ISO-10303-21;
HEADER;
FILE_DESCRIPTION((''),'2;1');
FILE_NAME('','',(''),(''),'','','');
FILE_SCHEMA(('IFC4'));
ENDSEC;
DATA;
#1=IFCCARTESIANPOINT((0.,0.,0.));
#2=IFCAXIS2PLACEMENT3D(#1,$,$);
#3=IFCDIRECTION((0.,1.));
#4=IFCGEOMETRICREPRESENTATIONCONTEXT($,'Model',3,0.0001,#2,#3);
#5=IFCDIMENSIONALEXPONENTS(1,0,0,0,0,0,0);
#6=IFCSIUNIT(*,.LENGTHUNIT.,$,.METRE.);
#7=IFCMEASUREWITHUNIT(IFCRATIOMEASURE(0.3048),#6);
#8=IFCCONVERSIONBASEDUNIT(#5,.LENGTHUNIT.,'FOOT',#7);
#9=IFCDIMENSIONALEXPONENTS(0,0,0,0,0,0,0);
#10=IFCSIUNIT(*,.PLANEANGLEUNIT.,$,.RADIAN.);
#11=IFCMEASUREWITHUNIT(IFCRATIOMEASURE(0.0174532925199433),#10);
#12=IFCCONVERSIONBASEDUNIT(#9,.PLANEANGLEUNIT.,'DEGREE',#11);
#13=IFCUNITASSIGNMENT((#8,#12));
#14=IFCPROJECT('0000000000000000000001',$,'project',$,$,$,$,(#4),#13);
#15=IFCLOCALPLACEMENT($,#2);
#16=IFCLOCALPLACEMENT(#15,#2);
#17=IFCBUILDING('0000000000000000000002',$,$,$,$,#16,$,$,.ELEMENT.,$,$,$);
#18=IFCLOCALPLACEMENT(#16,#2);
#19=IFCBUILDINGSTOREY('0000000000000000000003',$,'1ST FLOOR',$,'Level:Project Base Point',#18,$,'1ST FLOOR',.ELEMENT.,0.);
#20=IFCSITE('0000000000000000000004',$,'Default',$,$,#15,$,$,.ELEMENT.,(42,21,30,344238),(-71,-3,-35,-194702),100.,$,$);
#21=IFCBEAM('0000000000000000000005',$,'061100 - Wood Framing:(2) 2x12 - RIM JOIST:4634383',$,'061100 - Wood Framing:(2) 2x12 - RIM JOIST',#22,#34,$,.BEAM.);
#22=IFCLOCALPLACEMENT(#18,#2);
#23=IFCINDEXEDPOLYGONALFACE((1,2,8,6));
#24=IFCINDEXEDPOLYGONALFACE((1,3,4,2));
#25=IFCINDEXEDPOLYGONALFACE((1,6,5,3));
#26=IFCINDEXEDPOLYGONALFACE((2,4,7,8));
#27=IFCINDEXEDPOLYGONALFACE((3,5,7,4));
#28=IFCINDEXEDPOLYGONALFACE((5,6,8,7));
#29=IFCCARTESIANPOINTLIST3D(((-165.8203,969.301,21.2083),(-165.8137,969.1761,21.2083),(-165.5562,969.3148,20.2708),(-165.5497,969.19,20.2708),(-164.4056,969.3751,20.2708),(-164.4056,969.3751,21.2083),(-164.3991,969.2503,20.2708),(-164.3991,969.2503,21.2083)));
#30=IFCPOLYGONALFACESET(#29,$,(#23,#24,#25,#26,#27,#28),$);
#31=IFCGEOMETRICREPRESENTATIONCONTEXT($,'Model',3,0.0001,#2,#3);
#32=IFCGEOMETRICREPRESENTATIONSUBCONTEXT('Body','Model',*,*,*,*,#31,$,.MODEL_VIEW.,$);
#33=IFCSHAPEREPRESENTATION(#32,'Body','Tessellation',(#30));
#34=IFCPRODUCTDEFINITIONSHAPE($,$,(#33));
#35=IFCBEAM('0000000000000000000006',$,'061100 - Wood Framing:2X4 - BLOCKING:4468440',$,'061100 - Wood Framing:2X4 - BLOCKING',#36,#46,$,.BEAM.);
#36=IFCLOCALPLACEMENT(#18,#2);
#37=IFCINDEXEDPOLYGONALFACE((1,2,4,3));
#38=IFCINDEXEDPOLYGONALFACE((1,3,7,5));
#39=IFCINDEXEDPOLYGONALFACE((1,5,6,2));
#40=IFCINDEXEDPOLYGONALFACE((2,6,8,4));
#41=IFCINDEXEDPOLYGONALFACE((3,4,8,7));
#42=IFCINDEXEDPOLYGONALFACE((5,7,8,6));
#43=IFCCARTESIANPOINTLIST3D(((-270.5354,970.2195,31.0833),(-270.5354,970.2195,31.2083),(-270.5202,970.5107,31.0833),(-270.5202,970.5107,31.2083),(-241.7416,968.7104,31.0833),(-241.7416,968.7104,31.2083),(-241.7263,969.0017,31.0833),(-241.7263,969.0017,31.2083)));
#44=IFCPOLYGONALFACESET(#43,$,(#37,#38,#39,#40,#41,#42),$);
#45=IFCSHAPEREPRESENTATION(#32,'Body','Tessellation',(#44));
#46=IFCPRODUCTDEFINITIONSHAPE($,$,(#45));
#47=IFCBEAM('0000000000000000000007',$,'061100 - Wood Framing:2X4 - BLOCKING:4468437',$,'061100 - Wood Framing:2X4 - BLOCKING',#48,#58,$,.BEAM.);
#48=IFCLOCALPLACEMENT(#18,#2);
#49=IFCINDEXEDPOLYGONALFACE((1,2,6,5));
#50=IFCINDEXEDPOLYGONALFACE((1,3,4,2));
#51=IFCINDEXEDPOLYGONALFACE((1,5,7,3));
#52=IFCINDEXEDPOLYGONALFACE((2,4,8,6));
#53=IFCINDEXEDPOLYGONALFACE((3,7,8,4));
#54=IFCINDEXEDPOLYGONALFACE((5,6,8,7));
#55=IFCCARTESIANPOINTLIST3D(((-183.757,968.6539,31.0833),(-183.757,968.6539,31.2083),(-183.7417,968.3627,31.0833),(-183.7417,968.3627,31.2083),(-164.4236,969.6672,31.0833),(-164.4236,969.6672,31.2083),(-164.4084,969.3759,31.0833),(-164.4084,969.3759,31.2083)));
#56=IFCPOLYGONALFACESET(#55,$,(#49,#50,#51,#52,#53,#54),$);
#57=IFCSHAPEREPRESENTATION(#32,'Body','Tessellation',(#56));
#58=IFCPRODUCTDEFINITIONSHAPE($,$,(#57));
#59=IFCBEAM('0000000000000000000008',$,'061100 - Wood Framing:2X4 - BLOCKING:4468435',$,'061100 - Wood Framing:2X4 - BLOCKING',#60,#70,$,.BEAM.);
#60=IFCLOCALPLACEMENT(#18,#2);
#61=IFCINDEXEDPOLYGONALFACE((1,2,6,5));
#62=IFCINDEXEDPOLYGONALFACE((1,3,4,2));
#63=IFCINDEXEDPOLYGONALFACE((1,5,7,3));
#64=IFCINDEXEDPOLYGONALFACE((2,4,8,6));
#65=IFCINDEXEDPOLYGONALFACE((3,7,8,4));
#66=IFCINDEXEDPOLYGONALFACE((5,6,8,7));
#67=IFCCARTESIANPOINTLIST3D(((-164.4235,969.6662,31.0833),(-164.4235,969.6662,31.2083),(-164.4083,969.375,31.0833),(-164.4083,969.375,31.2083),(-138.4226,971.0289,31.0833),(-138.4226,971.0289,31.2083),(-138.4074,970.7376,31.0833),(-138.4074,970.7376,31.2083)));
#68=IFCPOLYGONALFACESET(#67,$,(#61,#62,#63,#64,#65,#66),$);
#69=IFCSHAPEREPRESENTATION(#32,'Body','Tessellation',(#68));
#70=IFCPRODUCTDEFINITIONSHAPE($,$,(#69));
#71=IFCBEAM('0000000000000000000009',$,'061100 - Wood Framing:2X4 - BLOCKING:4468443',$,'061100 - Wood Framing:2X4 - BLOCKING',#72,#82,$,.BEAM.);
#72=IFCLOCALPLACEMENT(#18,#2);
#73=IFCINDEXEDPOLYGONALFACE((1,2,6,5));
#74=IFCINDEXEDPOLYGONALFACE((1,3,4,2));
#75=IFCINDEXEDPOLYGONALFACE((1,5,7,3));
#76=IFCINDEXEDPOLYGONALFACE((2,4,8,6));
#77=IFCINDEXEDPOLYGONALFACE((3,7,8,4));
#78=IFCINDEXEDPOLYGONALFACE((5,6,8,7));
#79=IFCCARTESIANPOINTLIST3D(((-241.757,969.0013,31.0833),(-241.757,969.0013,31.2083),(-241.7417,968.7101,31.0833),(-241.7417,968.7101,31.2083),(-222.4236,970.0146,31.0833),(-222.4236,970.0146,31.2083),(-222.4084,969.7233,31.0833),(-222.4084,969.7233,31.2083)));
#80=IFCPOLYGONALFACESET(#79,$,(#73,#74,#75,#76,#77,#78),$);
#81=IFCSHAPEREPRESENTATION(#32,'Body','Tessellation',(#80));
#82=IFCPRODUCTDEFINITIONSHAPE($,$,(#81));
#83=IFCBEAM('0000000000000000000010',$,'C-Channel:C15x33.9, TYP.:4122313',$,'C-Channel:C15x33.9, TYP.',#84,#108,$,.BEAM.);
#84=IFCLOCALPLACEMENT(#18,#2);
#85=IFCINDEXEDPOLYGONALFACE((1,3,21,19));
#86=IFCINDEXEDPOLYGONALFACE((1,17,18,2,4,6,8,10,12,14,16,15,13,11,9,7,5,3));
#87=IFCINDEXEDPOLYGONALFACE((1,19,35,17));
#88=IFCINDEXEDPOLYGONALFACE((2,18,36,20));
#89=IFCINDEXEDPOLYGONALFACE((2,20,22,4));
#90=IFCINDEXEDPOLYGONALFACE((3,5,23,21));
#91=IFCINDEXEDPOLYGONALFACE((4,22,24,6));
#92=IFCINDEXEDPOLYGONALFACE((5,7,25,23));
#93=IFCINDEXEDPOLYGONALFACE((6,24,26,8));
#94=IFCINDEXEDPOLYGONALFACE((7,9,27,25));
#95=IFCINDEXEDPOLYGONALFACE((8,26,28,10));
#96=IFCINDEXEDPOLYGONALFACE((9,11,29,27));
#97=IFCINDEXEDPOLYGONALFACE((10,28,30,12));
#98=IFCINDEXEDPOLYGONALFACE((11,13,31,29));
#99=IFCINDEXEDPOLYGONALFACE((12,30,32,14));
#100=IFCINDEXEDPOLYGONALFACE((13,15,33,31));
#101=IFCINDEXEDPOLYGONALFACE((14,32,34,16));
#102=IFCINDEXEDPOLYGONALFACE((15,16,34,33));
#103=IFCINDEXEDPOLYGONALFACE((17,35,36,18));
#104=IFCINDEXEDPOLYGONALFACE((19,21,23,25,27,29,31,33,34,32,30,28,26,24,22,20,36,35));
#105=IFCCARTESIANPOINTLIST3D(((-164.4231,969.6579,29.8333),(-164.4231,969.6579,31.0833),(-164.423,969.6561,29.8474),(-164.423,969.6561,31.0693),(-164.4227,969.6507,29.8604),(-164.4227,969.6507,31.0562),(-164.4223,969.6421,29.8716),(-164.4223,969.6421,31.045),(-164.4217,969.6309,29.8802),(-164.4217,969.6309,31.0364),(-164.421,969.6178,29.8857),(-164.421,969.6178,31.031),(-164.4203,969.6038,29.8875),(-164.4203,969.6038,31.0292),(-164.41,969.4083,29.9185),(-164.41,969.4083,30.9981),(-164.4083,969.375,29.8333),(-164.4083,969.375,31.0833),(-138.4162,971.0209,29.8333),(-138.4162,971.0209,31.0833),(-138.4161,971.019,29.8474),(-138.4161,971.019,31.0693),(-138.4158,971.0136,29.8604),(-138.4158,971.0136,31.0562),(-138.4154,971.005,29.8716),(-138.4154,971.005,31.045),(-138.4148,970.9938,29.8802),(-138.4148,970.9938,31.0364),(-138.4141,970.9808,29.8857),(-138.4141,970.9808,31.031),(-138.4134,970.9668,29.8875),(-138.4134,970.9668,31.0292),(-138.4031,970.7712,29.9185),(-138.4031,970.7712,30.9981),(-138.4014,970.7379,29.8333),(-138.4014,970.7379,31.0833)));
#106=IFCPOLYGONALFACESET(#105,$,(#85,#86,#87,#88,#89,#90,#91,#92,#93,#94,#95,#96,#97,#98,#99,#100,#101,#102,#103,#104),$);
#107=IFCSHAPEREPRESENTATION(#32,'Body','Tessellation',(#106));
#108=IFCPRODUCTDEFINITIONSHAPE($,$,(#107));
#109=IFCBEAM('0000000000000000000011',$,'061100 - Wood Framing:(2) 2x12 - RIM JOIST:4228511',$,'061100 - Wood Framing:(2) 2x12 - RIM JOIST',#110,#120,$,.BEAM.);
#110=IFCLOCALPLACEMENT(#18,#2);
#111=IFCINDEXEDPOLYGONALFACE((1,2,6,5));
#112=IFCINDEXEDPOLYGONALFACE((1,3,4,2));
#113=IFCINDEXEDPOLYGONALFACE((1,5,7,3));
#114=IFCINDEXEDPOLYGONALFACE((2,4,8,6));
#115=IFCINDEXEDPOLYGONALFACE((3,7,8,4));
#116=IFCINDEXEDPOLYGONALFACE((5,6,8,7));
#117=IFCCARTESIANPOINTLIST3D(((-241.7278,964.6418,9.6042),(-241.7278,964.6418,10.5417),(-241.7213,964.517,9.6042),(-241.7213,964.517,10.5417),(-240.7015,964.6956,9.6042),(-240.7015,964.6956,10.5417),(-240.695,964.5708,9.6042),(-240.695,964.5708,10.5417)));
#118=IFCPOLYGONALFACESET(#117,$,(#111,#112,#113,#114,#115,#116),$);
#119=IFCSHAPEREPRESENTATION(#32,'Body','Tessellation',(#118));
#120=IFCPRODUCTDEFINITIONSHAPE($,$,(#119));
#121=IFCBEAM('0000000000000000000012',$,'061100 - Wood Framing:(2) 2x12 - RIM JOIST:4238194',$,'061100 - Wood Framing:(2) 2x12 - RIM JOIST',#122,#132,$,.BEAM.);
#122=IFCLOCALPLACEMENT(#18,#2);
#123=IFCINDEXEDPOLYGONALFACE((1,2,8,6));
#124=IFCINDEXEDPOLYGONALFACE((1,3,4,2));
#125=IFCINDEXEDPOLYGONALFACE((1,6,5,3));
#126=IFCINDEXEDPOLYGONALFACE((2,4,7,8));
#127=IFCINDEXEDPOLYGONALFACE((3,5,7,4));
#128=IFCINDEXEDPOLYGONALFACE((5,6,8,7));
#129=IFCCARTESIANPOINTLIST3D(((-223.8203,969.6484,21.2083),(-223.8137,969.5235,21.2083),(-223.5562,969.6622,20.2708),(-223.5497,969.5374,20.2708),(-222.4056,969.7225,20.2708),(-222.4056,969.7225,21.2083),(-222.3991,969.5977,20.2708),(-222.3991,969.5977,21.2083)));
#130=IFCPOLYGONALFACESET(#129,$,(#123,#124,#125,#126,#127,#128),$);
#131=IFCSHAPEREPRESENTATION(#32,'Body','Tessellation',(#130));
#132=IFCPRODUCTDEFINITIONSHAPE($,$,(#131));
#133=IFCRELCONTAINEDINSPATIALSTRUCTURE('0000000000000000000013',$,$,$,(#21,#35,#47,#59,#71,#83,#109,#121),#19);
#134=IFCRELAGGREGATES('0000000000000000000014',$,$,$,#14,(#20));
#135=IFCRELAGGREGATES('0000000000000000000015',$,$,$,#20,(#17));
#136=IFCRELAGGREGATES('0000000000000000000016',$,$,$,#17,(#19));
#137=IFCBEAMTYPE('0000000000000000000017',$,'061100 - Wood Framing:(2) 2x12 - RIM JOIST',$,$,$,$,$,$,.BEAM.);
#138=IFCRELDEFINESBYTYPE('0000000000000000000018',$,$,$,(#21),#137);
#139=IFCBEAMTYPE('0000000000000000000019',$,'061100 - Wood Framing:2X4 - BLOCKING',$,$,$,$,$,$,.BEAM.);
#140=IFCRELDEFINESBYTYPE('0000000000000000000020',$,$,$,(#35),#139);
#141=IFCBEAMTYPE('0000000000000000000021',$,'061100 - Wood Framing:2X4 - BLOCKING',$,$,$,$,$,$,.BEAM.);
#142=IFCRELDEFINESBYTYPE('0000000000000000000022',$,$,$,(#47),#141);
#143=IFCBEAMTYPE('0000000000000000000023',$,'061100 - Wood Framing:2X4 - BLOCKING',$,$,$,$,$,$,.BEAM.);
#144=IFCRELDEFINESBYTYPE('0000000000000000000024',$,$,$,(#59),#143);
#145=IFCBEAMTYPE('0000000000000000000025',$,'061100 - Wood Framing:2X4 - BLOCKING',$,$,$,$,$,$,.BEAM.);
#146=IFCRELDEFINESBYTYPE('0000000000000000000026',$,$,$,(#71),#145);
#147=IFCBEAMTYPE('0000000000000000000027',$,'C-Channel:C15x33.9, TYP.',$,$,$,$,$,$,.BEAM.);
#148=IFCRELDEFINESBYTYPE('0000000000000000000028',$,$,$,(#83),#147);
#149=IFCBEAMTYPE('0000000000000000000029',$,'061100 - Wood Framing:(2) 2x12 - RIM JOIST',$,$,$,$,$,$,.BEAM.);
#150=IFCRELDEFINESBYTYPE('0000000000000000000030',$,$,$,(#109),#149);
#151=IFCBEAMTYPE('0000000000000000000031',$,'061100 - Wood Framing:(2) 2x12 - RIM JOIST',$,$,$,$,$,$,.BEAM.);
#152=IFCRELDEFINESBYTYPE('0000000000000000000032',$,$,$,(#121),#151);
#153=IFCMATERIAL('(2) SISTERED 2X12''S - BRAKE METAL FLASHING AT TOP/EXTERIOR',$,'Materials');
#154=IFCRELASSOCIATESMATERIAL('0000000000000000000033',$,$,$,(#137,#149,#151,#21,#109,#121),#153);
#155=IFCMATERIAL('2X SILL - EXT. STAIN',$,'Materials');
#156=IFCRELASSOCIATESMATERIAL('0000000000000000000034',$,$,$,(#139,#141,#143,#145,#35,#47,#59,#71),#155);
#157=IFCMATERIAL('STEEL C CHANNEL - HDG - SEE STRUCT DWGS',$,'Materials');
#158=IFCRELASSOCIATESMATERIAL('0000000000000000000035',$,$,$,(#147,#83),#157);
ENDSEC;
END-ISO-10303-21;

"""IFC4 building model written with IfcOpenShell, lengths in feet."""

from ifc_helpers import new_model, entity, si_unit, converted_unit, direction, frame, frame_2d, origin, origin_2d_with_axis, place, context, subcontext, project, spatial, polyline, circle_curve, parameter, trimmed, segment, composite_curve, rectangle, outline, extrude, clip, halfspace, source, transform, mapped, material, material_profile, profile_set, profile_usage, type_object, type_shapes, element, save


model = new_model("IFC4")

# Units and contexts
model_context_1 = context("Model", 3, precision=0.0001, world=origin(), true_north=direction((0.0, 1.0)))
model_context_2 = context("Model", 3, precision=0.0001, world=origin(), true_north=direction((0.0, 1.0)))
body_context = subcontext(model_context_2, "Body", "Model", "MODEL_VIEW")
ifc_project = project(units=[converted_unit("LENGTHUNIT", "FOOT", entity("IfcRatioMeasure", 0.3048), si_unit("LENGTHUNIT", "METRE"), dimensions=[1, 0, 0, 0, 0, 0, 0]), converted_unit("PLANEANGLEUNIT", "DEGREE", entity("IfcRatioMeasure", 0.0174532925199433), si_unit("PLANEANGLEUNIT", "RADIAN"), dimensions=[0, 0, 0, 0, 0, 0, 0])], contexts=[model_context_1])

# Site, building, storey
site_placement = place(None, origin())
site = spatial("IfcSite", under=ifc_project, at=site_placement, Name="Default", CompositionType="ELEMENT", RefLatitude=(42, 21, 30, 344238), RefLongitude=(-71, -3, -35, -194702), RefElevation=100.0)
building_placement = place(site_placement, origin())
building = spatial("IfcBuilding", under=site, at=building_placement, CompositionType="ELEMENT")
storey_placement = place(building_placement, origin())
storey = spatial("IfcBuildingStorey", under=building, at=storey_placement, Name="1ST FLOOR", ObjectType="Level:Project Base Point", LongName="1ST FLOOR", CompositionType="ELEMENT", Elevation=0.0)

# Beams
ifc_material_1 = material(Name="STEEL C CHANNEL - HDG - SEE STRUCT DWGS", Category="Materials")
ifc_material_profile_1 = material_profile(ifc_material_1, outline(composite_curve([segment(polyline([(0.0323, -0.5398, 0.0), (0.0323, 0.5398, 0.0)]), True, "CONTINUOUS"), segment(polyline([(0.0323, 0.5398, 0.0), (-0.1635, 0.5708, 0.0)]), True, "CONTINUOUS"), segment(trimmed(circle_curve(frame((-0.1635, 0.625, 0.0), z_axis=(0.0, 0.0, -1.0), x_axis=(-1.0, 0.0, 0.0)), 0.0542), [parameter(270.0)], [parameter(360.0)], True, "PARAMETER"), True, "CONTINUOUS"), segment(polyline([(-0.2177, 0.625, 0.0), (0.0657, 0.625, 0.0)]), True, "CONTINUOUS"), segment(polyline([(0.0657, 0.625, 0.0), (0.0657, -0.625, 0.0)]), True, "CONTINUOUS"), segment(polyline([(0.0657, -0.625, 0.0), (-0.2177, -0.625, 0.0)]), True, "CONTINUOUS"), segment(trimmed(circle_curve(frame((-0.1635, -0.625, 0.0), z_axis=(0.0, 0.0, -1.0), x_axis=(-1.0, 0.0, 0.0)), 0.0542), [parameter(0.0)], [parameter(90.0)], True, "PARAMETER"), True, "CONTINUOUS"), segment(polyline([(-0.1635, -0.5708, 0.0), (0.0323, -0.5398, 0.0)]), True, "CONTINUOUS")], self_intersect=False), kind="CURVE"), Name="C15x33.9, TYP.")
ifc_profile_set_1 = profile_set([ifc_material_profile_1], Name="C15x33.9, TYP.")
ifc_material_2 = material(Name="(2) SISTERED 2X12'S - BRAKE METAL FLASHING AT TOP/EXTERIOR", Category="Materials")
ifc_material_profile_2 = material_profile(ifc_material_2, rectangle(XDim=0.9375, YDim=0.125, at=frame_2d((0.0, 0.0), x_axis=(1.0, 0.0))), Name="(2) 2x12 - RIM JOIST")
ifc_profile_set_2 = profile_set([ifc_material_profile_2], Name="(2) 2x12 - RIM JOIST")
ifc_profile_usage_1 = profile_usage(ifc_profile_set_2, cardinal=2)
beam_type_1 = type_object("IfcBeamType", Name="061100 - Wood Framing:(2) 2x12 - RIM JOIST", PredefinedType="BEAM", material=ifc_profile_set_2)
shared_shape_1 = source(origin(), body_context, "Body", "Clipping", [
    clip(extrude(rectangle(XDim=0.9375, YDim=0.125, at=frame_2d((0.0, 0.0), x_axis=(1.0, 0.0))), frame((-165.817, 969.2386, 20.7396), z_axis=(0.99863, 0.052336, 0.0), x_axis=(0.0, 0.0, 1.0)), (0.0, 0.0, 1.0), 1.4166), halfspace(frame((-165.2632, 966.0702, 19.8354), z_axis=(-0.961136, -0.050371, -0.27144), x_axis=(0.271068, 0.014206, -0.962455)), False)),
])
type_shapes(beam_type_1, [shared_shape_1])
beam_1_placement = place(storey_placement, origin())
element("IfcBeam", 1, at=beam_1_placement, inside=storey, type_object=beam_type_1, material=ifc_profile_usage_1, Name="061100 - Wood Framing:(2) 2x12 - RIM JOIST:4634383", ObjectType="061100 - Wood Framing:(2) 2x12 - RIM JOIST", PredefinedType="BEAM", context=body_context, shape_type="MappedRepresentation", body=[
    mapped(shared_shape_1, transform((0.0, 0.0, 0.0), scale=1.0)),
])
ifc_material_3 = material(Name="2X SILL - EXT. STAIN", Category="Materials")
ifc_material_profile_3 = material_profile(ifc_material_3, rectangle(XDim=0.125, YDim=0.2917, at=origin_2d_with_axis()), Name="2X4 - BLOCKING")
ifc_profile_set_3 = profile_set([ifc_material_profile_3], Name="2X4 - BLOCKING")
ifc_profile_usage_2 = profile_usage(ifc_profile_set_3, cardinal=8)
beam_type_2 = type_object("IfcBeamType", Name="061100 - Wood Framing:2X4 - BLOCKING", PredefinedType="BEAM", material=ifc_profile_set_3)
shared_shape_2 = source(origin(), body_context, "Body", "SweptSolid", [
    extrude(rectangle(XDim=0.125, YDim=0.2917, at=frame_2d((0.0, 0.0), x_axis=(1.0, 0.0))), frame((-241.734, 968.8561, 31.1458), z_axis=(-0.99863, 0.052336, 0.0), x_axis=(0.0, 0.0, 1.0)), (0.0, 0.0, 1.0), 28.8333),
])
type_shapes(beam_type_2, [shared_shape_2])
beam_2_placement = place(storey_placement, origin())
element("IfcBeam", 2, at=beam_2_placement, inside=storey, type_object=beam_type_2, material=ifc_profile_usage_2, Name="061100 - Wood Framing:2X4 - BLOCKING:4468440", ObjectType="061100 - Wood Framing:2X4 - BLOCKING", PredefinedType="BEAM", context=body_context, shape_type="MappedRepresentation", body=[
    mapped(shared_shape_2, transform((0.0, 0.0, 0.0), scale=1.0)),
])
ifc_profile_usage_3 = profile_usage(ifc_profile_set_3, cardinal=8)
beam_type_3 = type_object("IfcBeamType", Name="061100 - Wood Framing:2X4 - BLOCKING", PredefinedType="BEAM", material=ifc_profile_set_3)
shared_shape_3 = source(origin(), body_context, "Body", "SweptSolid", [
    extrude(rectangle(XDim=0.125, YDim=0.2917, at=frame_2d((0.0, 0.0), x_axis=(1.0, 0.0))), frame((-164.416, 969.5215, 31.1458), z_axis=(-0.99863, -0.052336, 0.0), x_axis=(0.0, 0.0, -1.0)), (0.0, 0.0, 1.0), 19.3599),
])
type_shapes(beam_type_3, [shared_shape_3])
beam_3_placement = place(storey_placement, origin())
element("IfcBeam", 3, at=beam_3_placement, inside=storey, type_object=beam_type_3, material=ifc_profile_usage_3, Name="061100 - Wood Framing:2X4 - BLOCKING:4468437", ObjectType="061100 - Wood Framing:2X4 - BLOCKING", PredefinedType="BEAM", context=body_context, shape_type="MappedRepresentation", body=[
    mapped(shared_shape_3, transform((0.0, 0.0, 0.0), scale=1.0)),
])
ifc_profile_usage_4 = profile_usage(ifc_profile_set_3, cardinal=8)
beam_type_4 = type_object("IfcBeamType", Name="061100 - Wood Framing:2X4 - BLOCKING", PredefinedType="BEAM", material=ifc_profile_set_3)
shared_shape_4 = source(origin(), body_context, "Body", "SweptSolid", [
    extrude(rectangle(XDim=0.125, YDim=0.2917, at=origin_2d_with_axis()), frame((-164.4159, 969.5206, 31.1458), z_axis=(0.99863, 0.052336, 0.0), x_axis=(0.0, 0.0, 1.0)), (0.0, 0.0, 1.0), 26.0366),
])
type_shapes(beam_type_4, [shared_shape_4])
beam_4_placement = place(storey_placement, origin())
element("IfcBeam", 4, at=beam_4_placement, inside=storey, type_object=beam_type_4, material=ifc_profile_usage_4, Name="061100 - Wood Framing:2X4 - BLOCKING:4468435", ObjectType="061100 - Wood Framing:2X4 - BLOCKING", PredefinedType="BEAM", context=body_context, shape_type="MappedRepresentation", body=[
    mapped(shared_shape_4, transform((0.0, 0.0, 0.0), scale=1.0)),
])
ifc_profile_usage_5 = profile_usage(ifc_profile_set_3, cardinal=8)
beam_type_5 = type_object("IfcBeamType", Name="061100 - Wood Framing:2X4 - BLOCKING", PredefinedType="BEAM", material=ifc_profile_set_3)
shared_shape_5 = source(origin(), body_context, "Body", "SweptSolid", [
    extrude(rectangle(XDim=0.125, YDim=0.2917, at=frame_2d((0.0, 0.0), x_axis=(1.0, 0.0))), frame((-222.416, 969.8689, 31.1458), z_axis=(-0.99863, -0.052336, 0.0), x_axis=(0.0, 0.0, -1.0)), (0.0, 0.0, 1.0), 19.3599),
])
type_shapes(beam_type_5, [shared_shape_5])
beam_5_placement = place(storey_placement, origin())
element("IfcBeam", 5, at=beam_5_placement, inside=storey, type_object=beam_type_5, material=ifc_profile_usage_5, Name="061100 - Wood Framing:2X4 - BLOCKING:4468443", ObjectType="061100 - Wood Framing:2X4 - BLOCKING", PredefinedType="BEAM", context=body_context, shape_type="MappedRepresentation", body=[
    mapped(shared_shape_5, transform((0.0, 0.0, 0.0), scale=1.0)),
])
ifc_profile_usage_6 = profile_usage(ifc_profile_set_1, cardinal=8)
beam_type_6 = type_object("IfcBeamType", Name="C-Channel:C15x33.9, TYP.", PredefinedType="BEAM", material=ifc_profile_set_1)
shared_shape_6 = source(origin(), body_context, "Body", "SweptSolid", [
    extrude(outline(composite_curve([segment(polyline([(-0.1469, -0.625), (0.1365, -0.625)]), True, "CONTINUOUS"), segment(polyline([(0.1365, -0.625), (0.1365, 0.625)]), True, "CONTINUOUS"), segment(polyline([(0.1365, 0.625), (-0.1469, 0.625)]), True, "CONTINUOUS"), segment(trimmed(circle_curve(frame_2d((-0.0927, 0.625), x_axis=(-1.0, 0.0)), 0.0542), [parameter(0.0)], [parameter(90.0)], True, "PARAMETER"), True, "CONTINUOUS"), segment(polyline([(-0.0927, 0.5708), (0.1031, 0.5398)]), True, "CONTINUOUS"), segment(polyline([(0.1031, 0.5398), (0.1031, -0.5398)]), True, "CONTINUOUS"), segment(polyline([(0.1031, -0.5398), (-0.0927, -0.5708)]), True, "CONTINUOUS"), segment(trimmed(circle_curve(frame_2d((-0.0927, -0.625), x_axis=(0.0, 1.0)), 0.0542), [parameter(0.0)], [parameter(90.0)], True, "PARAMETER"), True, "CONTINUOUS")], self_intersect=False)), frame((-164.4154, 969.5112, 30.4583), z_axis=(0.99863, 0.052336, 0.0), x_axis=(0.052336, -0.99863, 0.0)), (0.0, 0.0, 1.0), 26.0426),
])
type_shapes(beam_type_6, [shared_shape_6])
beam_6_placement = place(storey_placement, origin())
element("IfcBeam", 6, at=beam_6_placement, inside=storey, type_object=beam_type_6, material=ifc_profile_usage_6, Name="C-Channel:C15x33.9, TYP.:4122313", ObjectType="C-Channel:C15x33.9, TYP.", PredefinedType="BEAM", context=body_context, shape_type="MappedRepresentation", body=[
    mapped(shared_shape_6, transform((0.0, 0.0, 0.0), scale=1.0)),
])
ifc_profile_usage_7 = profile_usage(ifc_profile_set_2, cardinal=2)
beam_type_7 = type_object("IfcBeamType", Name="061100 - Wood Framing:(2) 2x12 - RIM JOIST", PredefinedType="BEAM", material=ifc_profile_set_2)
shared_shape_7 = source(origin(), body_context, "Body", "SweptSolid", [
    extrude(rectangle(XDim=0.9375, YDim=0.125, at=frame_2d((0.0, 0.0), x_axis=(1.0, 0.0))), frame((-241.7246, 964.5794, 10.0729), z_axis=(0.99863, 0.052336, 0.0), x_axis=(0.0, 0.0, 1.0)), (0.0, 0.0, 1.0), 1.0278),
])
type_shapes(beam_type_7, [shared_shape_7])
beam_7_placement = place(storey_placement, origin())
element("IfcBeam", 7, at=beam_7_placement, inside=storey, type_object=beam_type_7, material=ifc_profile_usage_7, Name="061100 - Wood Framing:(2) 2x12 - RIM JOIST:4228511", ObjectType="061100 - Wood Framing:(2) 2x12 - RIM JOIST", PredefinedType="BEAM", context=body_context, shape_type="MappedRepresentation", body=[
    mapped(shared_shape_7, transform((0.0, 0.0, 0.0), scale=1.0)),
])
ifc_profile_usage_8 = profile_usage(ifc_profile_set_2, cardinal=2)
beam_type_8 = type_object("IfcBeamType", Name="061100 - Wood Framing:(2) 2x12 - RIM JOIST", PredefinedType="BEAM", material=ifc_profile_set_2)
shared_shape_8 = source(origin(), body_context, "Body", "Clipping", [
    clip(extrude(rectangle(XDim=0.9375, YDim=0.125, at=frame_2d((0.0, 0.0), x_axis=(1.0, 0.0))), frame((-223.817, 969.586, 20.7396), z_axis=(0.99863, 0.052336, 0.0), x_axis=(0.0, 0.0, 1.0)), (0.0, 0.0, 1.0), 1.4166), halfspace(frame((-223.2632, 966.4176, 19.8354), z_axis=(-0.961136, -0.050371, -0.27144), x_axis=(0.271068, 0.014206, -0.962455)), False)),
])
type_shapes(beam_type_8, [shared_shape_8])
beam_8_placement = place(storey_placement, origin())
element("IfcBeam", 8, at=beam_8_placement, inside=storey, type_object=beam_type_8, material=ifc_profile_usage_8, Name="061100 - Wood Framing:(2) 2x12 - RIM JOIST:4238194", ObjectType="061100 - Wood Framing:(2) 2x12 - RIM JOIST", PredefinedType="BEAM", context=body_context, shape_type="MappedRepresentation", body=[
    mapped(shared_shape_8, transform((0.0, 0.0, 0.0), scale=1.0)),
])

save(model, "model.ifc")
